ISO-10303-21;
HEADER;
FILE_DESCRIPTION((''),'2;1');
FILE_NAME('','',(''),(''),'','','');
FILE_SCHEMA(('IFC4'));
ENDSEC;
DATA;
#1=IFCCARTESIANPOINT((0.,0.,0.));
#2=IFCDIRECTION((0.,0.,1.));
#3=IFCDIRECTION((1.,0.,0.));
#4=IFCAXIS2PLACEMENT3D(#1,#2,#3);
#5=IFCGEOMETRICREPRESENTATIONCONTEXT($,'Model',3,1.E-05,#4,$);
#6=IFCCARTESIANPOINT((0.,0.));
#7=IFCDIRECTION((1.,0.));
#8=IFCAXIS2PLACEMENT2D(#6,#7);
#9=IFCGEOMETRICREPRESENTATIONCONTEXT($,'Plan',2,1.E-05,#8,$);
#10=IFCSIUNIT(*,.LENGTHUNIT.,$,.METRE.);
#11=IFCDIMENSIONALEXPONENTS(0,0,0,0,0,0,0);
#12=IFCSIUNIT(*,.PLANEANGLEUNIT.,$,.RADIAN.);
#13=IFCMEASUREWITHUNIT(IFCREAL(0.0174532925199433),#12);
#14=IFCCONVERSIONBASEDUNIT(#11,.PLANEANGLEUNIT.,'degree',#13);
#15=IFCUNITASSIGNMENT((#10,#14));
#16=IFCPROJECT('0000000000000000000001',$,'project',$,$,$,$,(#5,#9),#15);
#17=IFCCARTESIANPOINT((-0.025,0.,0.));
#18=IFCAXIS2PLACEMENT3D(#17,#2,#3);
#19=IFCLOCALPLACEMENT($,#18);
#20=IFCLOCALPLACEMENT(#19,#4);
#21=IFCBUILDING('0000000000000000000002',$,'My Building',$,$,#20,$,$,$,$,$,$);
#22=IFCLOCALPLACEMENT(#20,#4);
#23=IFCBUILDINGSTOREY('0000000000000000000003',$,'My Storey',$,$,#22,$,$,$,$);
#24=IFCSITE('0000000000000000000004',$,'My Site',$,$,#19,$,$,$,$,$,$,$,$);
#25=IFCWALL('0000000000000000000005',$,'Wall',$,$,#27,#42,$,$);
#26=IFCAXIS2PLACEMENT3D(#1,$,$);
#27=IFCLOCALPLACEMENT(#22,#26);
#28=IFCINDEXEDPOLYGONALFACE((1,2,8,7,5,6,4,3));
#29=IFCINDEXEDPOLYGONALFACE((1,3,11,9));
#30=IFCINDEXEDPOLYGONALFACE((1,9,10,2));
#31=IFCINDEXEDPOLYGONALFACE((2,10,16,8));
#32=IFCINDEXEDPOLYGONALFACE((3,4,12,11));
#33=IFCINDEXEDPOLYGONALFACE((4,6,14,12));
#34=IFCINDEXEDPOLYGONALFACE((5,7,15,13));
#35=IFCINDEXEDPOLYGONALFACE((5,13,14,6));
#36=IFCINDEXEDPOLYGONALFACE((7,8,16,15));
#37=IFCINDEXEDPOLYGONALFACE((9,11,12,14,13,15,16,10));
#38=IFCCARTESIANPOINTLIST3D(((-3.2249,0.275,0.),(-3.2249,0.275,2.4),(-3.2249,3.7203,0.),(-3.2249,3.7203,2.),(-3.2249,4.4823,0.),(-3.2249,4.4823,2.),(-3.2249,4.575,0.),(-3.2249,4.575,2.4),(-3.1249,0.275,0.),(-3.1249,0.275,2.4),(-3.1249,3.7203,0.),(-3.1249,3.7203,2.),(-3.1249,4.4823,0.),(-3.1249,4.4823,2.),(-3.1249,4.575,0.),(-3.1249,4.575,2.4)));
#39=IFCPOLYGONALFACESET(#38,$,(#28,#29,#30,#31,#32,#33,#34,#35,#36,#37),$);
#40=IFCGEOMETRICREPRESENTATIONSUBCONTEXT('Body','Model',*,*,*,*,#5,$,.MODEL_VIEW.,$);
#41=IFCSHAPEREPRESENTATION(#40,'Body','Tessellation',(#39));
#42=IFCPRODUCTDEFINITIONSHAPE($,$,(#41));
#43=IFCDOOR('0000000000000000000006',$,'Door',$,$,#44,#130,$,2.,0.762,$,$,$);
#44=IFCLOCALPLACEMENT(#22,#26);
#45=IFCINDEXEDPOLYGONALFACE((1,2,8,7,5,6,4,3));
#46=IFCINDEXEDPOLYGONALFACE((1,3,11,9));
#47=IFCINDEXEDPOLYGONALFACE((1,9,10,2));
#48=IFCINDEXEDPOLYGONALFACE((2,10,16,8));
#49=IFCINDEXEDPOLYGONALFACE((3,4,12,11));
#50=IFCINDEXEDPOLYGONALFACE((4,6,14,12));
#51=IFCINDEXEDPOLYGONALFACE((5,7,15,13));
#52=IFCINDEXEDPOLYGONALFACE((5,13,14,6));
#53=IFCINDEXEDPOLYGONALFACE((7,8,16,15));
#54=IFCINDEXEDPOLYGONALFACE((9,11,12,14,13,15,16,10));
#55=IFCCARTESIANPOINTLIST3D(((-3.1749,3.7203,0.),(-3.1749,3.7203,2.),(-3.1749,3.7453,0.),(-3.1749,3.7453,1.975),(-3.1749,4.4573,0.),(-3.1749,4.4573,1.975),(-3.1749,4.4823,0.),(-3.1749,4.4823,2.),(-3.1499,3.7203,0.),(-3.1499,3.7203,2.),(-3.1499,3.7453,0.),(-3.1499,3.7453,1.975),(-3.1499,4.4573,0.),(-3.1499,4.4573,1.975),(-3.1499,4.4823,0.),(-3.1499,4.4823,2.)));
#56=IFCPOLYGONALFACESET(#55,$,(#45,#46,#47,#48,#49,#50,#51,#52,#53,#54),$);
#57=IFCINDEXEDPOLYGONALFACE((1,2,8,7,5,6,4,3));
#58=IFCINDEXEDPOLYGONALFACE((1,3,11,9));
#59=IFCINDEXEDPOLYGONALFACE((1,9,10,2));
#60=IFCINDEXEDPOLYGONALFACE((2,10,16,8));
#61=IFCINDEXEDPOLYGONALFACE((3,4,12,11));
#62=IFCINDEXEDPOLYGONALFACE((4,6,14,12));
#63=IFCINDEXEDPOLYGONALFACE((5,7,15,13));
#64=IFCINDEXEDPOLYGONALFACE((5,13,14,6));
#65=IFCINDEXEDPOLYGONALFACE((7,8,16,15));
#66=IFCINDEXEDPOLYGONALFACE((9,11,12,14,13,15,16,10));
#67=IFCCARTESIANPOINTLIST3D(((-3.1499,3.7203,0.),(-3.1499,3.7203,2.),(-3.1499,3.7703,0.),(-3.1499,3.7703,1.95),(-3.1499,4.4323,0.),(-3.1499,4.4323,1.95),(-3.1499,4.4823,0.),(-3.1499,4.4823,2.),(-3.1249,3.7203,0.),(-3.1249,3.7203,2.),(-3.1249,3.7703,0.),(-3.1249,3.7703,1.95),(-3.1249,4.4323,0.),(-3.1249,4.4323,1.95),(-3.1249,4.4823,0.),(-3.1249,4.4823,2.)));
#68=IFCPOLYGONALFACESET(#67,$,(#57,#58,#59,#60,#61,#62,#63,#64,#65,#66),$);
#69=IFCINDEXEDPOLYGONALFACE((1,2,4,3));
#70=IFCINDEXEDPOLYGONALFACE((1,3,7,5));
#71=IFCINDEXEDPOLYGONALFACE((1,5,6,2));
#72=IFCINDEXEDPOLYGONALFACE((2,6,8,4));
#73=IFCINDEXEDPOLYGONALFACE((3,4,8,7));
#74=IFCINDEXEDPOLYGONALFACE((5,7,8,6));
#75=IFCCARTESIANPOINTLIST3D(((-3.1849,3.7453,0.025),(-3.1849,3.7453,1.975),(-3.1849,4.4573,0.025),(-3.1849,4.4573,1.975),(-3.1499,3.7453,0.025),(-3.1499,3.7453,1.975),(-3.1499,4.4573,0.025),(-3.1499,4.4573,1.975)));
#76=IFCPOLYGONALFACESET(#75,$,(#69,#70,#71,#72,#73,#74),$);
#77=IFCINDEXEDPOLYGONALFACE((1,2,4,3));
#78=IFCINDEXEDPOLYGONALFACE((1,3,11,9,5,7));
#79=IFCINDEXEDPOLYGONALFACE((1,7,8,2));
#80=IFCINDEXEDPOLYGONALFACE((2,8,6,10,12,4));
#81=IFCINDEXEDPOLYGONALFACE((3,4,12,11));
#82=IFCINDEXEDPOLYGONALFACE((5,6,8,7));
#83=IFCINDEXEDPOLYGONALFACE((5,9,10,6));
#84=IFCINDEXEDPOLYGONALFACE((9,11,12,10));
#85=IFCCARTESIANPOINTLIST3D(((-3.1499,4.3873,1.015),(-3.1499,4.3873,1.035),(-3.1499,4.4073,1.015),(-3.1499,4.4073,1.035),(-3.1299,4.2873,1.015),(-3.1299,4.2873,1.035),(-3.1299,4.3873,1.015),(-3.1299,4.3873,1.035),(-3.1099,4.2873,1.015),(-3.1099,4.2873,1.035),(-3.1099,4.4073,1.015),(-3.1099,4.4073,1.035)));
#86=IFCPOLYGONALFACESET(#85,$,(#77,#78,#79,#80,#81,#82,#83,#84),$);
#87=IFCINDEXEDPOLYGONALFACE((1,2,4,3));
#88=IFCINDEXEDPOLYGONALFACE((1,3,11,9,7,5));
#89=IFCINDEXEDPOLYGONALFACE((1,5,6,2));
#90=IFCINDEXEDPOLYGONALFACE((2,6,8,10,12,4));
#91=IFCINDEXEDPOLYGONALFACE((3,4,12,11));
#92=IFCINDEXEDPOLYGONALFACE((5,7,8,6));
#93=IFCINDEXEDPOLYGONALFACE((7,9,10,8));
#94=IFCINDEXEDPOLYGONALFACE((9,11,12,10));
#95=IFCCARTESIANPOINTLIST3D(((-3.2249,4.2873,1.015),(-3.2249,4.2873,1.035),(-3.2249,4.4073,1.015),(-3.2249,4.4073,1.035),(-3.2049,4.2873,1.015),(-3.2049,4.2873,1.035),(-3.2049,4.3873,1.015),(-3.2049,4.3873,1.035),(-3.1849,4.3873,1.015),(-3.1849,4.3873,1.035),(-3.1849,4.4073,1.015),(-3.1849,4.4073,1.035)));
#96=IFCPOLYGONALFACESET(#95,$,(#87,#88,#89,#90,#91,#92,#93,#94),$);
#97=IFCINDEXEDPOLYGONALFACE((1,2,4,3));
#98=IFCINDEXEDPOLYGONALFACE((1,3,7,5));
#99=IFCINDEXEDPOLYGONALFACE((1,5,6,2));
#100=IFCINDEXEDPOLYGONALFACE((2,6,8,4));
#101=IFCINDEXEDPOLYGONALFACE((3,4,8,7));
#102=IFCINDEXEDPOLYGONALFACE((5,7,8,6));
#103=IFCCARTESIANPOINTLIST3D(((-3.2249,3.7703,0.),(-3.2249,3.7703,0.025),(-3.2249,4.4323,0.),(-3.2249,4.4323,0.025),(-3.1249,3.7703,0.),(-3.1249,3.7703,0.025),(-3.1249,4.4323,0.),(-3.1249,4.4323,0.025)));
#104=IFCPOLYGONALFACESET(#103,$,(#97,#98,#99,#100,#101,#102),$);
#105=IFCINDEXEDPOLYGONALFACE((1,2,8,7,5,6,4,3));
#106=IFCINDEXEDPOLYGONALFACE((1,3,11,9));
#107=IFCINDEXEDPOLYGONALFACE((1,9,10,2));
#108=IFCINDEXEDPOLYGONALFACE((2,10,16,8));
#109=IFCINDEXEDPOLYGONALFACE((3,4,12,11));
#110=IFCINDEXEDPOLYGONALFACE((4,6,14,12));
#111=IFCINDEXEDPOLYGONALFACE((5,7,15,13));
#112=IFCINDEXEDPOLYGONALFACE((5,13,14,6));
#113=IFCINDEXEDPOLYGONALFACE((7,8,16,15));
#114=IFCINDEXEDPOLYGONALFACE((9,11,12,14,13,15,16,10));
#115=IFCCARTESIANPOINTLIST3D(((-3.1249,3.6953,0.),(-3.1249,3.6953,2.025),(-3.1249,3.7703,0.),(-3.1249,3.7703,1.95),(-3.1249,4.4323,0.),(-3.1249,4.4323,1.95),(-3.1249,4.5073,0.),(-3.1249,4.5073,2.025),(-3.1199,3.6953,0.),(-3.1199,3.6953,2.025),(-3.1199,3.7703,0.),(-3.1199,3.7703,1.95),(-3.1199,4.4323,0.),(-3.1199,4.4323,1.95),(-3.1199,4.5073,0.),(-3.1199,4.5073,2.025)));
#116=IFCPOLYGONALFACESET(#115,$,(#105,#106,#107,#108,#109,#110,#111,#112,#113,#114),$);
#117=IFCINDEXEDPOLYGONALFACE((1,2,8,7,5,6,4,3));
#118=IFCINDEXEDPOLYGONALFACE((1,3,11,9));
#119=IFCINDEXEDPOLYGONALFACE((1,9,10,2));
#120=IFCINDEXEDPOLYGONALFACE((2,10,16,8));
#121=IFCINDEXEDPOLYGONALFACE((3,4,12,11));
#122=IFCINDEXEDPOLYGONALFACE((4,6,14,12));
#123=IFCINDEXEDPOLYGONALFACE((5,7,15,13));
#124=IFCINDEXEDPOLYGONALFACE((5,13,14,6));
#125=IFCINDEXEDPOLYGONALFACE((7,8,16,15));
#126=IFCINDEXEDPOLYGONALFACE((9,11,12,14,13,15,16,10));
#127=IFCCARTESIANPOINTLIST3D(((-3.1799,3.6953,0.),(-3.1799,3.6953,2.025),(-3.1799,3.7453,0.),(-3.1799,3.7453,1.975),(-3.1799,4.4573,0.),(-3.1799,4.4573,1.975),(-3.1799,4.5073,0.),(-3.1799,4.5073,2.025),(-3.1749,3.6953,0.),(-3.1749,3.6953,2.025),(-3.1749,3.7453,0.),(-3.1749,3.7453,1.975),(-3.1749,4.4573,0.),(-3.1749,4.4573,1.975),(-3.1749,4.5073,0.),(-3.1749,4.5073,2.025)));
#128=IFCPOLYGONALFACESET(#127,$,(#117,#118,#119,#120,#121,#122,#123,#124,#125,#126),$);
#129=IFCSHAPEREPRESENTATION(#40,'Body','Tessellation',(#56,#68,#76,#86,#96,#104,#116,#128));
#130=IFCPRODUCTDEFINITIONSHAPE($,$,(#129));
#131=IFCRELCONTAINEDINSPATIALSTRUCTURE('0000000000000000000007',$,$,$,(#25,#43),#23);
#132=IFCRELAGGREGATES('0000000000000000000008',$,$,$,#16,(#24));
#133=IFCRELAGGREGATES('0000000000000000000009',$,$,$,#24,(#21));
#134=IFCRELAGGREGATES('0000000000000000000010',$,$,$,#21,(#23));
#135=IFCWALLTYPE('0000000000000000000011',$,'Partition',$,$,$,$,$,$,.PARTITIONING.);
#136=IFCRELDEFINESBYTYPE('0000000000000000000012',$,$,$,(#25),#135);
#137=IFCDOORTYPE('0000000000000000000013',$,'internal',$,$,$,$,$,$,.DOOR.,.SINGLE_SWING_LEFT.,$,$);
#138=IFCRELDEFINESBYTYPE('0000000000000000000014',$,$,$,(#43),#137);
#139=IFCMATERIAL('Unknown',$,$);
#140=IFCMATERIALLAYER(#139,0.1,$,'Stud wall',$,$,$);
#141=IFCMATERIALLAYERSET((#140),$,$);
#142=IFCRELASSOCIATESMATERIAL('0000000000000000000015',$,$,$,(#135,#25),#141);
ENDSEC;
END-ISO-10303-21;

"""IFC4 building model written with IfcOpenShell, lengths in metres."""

from ifc_helpers import new_model, entity, si_unit, converted_unit, frame, origin_with_axes, origin_2d_with_axis, place, context, subcontext, project, spatial, line, indexed_curve, outline, extrude, shape, source, transform, mapped, material, layer, layer_set, layer_usage, type_object, type_shapes, element, fill, save


model = new_model("IFC4")

# Units and contexts
model_context = context("Model", 3, precision=1e-05, world=origin_with_axes())
plan_context = context("Plan", 2, precision=1e-05, world=origin_2d_with_axis())
body_context_1 = subcontext(model_context, "Body", "Model", "MODEL_VIEW")
body_context_2 = subcontext(plan_context, "Body", "Plan", "PLAN_VIEW")
ifc_project = project(units=[si_unit("LENGTHUNIT", "METRE"), converted_unit("PLANEANGLEUNIT", "degree", entity("IfcReal", 0.0174532925199433), si_unit("PLANEANGLEUNIT", "RADIAN"), dimensions=[0, 0, 0, 0, 0, 0, 0])], contexts=[model_context, plan_context])

# Site, building, storey
site_placement = place(None, frame((-0.025, 0.0, 0.0), z_axis=(0.0, 0.0, 1.0), x_axis=(1.0, 0.0, 0.0)))
site = spatial("IfcSite", under=ifc_project, at=site_placement, Name="My Site")
building_placement = place(site_placement, origin_with_axes())
building = spatial("IfcBuilding", under=site, at=building_placement, Name="My Building")
storey_placement = place(building_placement, origin_with_axes())
storey = spatial("IfcBuildingStorey", under=building, at=storey_placement, Name="My Storey")

# Shared definitions
ifc_material = material(Name="Unknown")
shared_shape_1 = source(origin_with_axes(), body_context_1, "Body", "SweptSolid", [
    extrude(outline(indexed_curve([(0.0, 0.0), (0.762, 0.0), (0.762, 2.0), (0.0, 2.0)], segments=[line(1, 2, 3, 4, 1)])), frame((0.0, -0.6, 0.0), z_axis=(0.0, -1.0, 0.0), x_axis=(1.0, 0.0, 0.0)), (0.0, 0.0, -1.0), 1.2),
])
door_type = type_object("IfcDoorType", Name="internal", OperationType="SINGLE_SWING_LEFT", PredefinedType="DOOR")
shared_shape_2 = source(origin_with_axes(), body_context_1, "Body", "SweptSolid", [
    extrude(outline(indexed_curve([(0.0, 0.0), (0.0, 2.0), (0.762, 2.0), (0.762, 0.0), (0.737, 0.0), (0.737, 1.975), (0.025, 1.975), (0.025, 0.0)], segments=[line(1, 2, 3, 4, 5, 6, 7, 8, 1)])), frame((0.0, 0.025, 0.0), z_axis=(0.0, -1.0, 0.0), x_axis=(1.0, 0.0, 0.0)), (0.0, 0.0, -1.0), 0.025),
    extrude(outline(indexed_curve([(0.0, 0.0), (0.0, 2.0), (0.762, 2.0), (0.762, 0.0), (0.712, 0.0), (0.712, 1.95), (0.05, 1.95), (0.05, 0.0)], segments=[line(1, 2, 3, 4, 5, 6, 7, 8, 1)])), frame((0.0, 0.0, 0.0), z_axis=(0.0, -1.0, 0.0), x_axis=(1.0, 0.0, 0.0)), (0.0, 0.0, -1.0), 0.025),
    extrude(outline(indexed_curve([(0.0, 0.0), (0.712, 0.0), (0.712, 0.035), (0.0, 0.035)], segments=[line(1, 2, 3, 4, 1)])), frame((0.025, 0.025, 0.025), z_axis=(0.0, 0.0, 1.0), x_axis=(1.0, 0.0, 0.0)), (0.0, 0.0, 1.0), 1.95),
    extrude(outline(indexed_curve([(0.0, 0.0), (0.0, -0.04), (-0.12, -0.04), (-0.12, -0.02), (-0.02, -0.02), (-0.02, 0.0)], segments=[line(1, 2, 3, 4, 5, 6, 1)])), frame((0.687, 0.025, 1.015), z_axis=(0.0, 0.0, 1.0), x_axis=(1.0, 0.0, 0.0)), (0.0, 0.0, 1.0), 0.02),
    extrude(outline(indexed_curve([(0.0, 0.0), (0.0, 0.04), (-0.12, 0.04), (-0.12, 0.02), (-0.02, 0.02), (-0.02, 0.0)], segments=[line(1, 2, 3, 4, 5, 6, 1)])), frame((0.687, 0.06, 1.015), z_axis=(0.0, 0.0, 1.0), x_axis=(1.0, 0.0, 0.0)), (0.0, 0.0, 1.0), 0.02),
    extrude(outline(indexed_curve([(0.0, 0.0), (0.662, 0.0), (0.662, 0.1), (0.0, 0.1)], segments=[line(1, 2, 3, 4, 1)])), frame((0.05, 0.0, 0.0), z_axis=(0.0, 0.0, 1.0), x_axis=(1.0, 0.0, 0.0)), (0.0, 0.0, 1.0), 0.025),
    extrude(outline(indexed_curve([(0.0, 0.0), (0.0, 2.025), (0.812, 2.025), (0.812, 0.0), (0.737, 0.0), (0.737, 1.95), (0.075, 1.95), (0.075, 0.0)], segments=[line(1, 2, 3, 4, 5, 6, 7, 8, 1)])), frame((-0.025, -0.005, 0.0), z_axis=(0.0, -1.0, 0.0), x_axis=(1.0, 0.0, 0.0)), (0.0, 0.0, -1.0), 0.005),
    extrude(outline(indexed_curve([(0.0, 0.0), (0.0, 2.025), (0.812, 2.025), (0.812, 0.0), (0.762, 0.0), (0.762, 1.975), (0.05, 1.975), (0.05, 0.0)], segments=[line(1, 2, 3, 4, 5, 6, 7, 8, 1)])), frame((-0.025, 0.05, 0.0), z_axis=(0.0, -1.0, 0.0), x_axis=(1.0, 0.0, 0.0)), (0.0, 0.0, -1.0), 0.005),
])
shared_shape_3 = source(origin_with_axes(), body_context_2, "Body", "Curve2D", [
    entity("IfcIndexedPolyCurve", entity("IfcCartesianPointList2D", [[0.0, 0.0], [0.0, 0.05], [0.025, 0.05], [0.025, 0.025], [0.05, 0.025], [0.05, 0.0]]), [entity("IfcLineIndex", [1, 2, 3, 4, 5, 6, 1])]),
    entity("IfcIndexedPolyCurve", entity("IfcCartesianPointList2D", [[0.762, 0.0], [0.762, 0.05], [0.737, 0.05], [0.737, 0.025], [0.712, 0.025], [0.712, 0.0]]), [entity("IfcLineIndex", [1, 2, 3, 4, 5, 6, 1])]),
    entity("IfcTrimmedCurve", entity("IfcEllipse", entity("IfcAxis2Placement2D", entity("IfcCartesianPoint", [0.06, 0.05]), entity("IfcDirection", [1.0, 0.0])), 0.677, 0.712), [entity("IfcCartesianPoint", [0.737, 0.05])], [entity("IfcCartesianPoint", [0.06, 0.762])], True, "CARTESIAN"),
    entity("IfcIndexedPolyCurve", entity("IfcCartesianPointList2D", [[0.025, 0.05], [0.06, 0.05], [0.06, 0.762], [0.025, 0.762]]), [entity("IfcLineIndex", [1, 2, 3, 4, 1])]),
])
type_shapes(door_type, [shared_shape_2, shared_shape_3])

# Wall, opening, door
ifc_layer_1 = layer(ifc_material, 0.1, Name="Stud wall")
ifc_layer_set_1 = layer_set([ifc_layer_1])
ifc_layer_usage_1 = layer_usage(ifc_layer_set_1, "AXIS2", "POSITIVE", 0.0)
wall_type_1 = type_object("IfcWallType", Name="Partition", PredefinedType="PARTITIONING", material=ifc_layer_set_1)
wall_1_placement = place(storey_placement, frame((-3.1249, 0.275, 0.0), z_axis=(0.0, 0.0, 1.0), x_axis=(0.0, 1.0, 0.0)))
wall_1 = element("IfcWall", 1, at=wall_1_placement, inside=storey, type_object=wall_type_1, material=ifc_layer_usage_1, Name="Wall", context=body_context_1, shape_type="SweptSolid", body=[
    extrude(outline(indexed_curve([(0.0, 0.0), (0.0, 0.1), (4.3, 0.1), (4.3, 0.0), (0.0, 0.0)], self_intersect=False)), origin_with_axes(), (0.0, 0.0, 1.0), 2.4),
])
opening_1_placement = place(wall_1_placement, frame((3.4453, 0.0, 0.0), z_axis=(0.0, 0.0, 1.0), x_axis=(1.0, 0.0, 0.0)))
opening_1 = element("IfcOpeningElement", 2, at=opening_1_placement, cuts=wall_1, PredefinedType="OPENING", context=body_context_1, shape_type="MappedRepresentation", body=[
    mapped(shared_shape_1, transform((0.0, 0.0, 0.0), x_axis=(1.0, 0.0, 0.0), y_axis=(0.0, 1.0, 0.0), z_axis=(0.0, 0.0, 1.0), scale=1.0)),
])
door_1_placement = place(opening_1_placement, frame((0.0, 0.0, 0.0), z_axis=(0.0, 0.0, 1.0), x_axis=(1.0, 0.0, 0.0)))
door_1 = element("IfcDoor", 3, at=door_1_placement, inside=storey, type_object=door_type, Name="Door", OverallHeight=2.0, OverallWidth=0.762, shapes=[
    shape(body_context_1, "Body", "MappedRepresentation", [mapped(shared_shape_2, transform((0.0, 0.0, 0.0), x_axis=(1.0, 0.0, 0.0), y_axis=(0.0, 1.0, 0.0), z_axis=(0.0, 0.0, 1.0), scale=1.0))]),
    shape(body_context_2, "Body", "MappedRepresentation", [mapped(shared_shape_3, transform((0.0, 0.0, 0.0), x_axis=(1.0, 0.0, 0.0), y_axis=(0.0, 1.0, 0.0), z_axis=(0.0, 0.0, 1.0), scale=1.0))]),
])
fill(opening_1, door_1)

save(model, "model.ifc")
